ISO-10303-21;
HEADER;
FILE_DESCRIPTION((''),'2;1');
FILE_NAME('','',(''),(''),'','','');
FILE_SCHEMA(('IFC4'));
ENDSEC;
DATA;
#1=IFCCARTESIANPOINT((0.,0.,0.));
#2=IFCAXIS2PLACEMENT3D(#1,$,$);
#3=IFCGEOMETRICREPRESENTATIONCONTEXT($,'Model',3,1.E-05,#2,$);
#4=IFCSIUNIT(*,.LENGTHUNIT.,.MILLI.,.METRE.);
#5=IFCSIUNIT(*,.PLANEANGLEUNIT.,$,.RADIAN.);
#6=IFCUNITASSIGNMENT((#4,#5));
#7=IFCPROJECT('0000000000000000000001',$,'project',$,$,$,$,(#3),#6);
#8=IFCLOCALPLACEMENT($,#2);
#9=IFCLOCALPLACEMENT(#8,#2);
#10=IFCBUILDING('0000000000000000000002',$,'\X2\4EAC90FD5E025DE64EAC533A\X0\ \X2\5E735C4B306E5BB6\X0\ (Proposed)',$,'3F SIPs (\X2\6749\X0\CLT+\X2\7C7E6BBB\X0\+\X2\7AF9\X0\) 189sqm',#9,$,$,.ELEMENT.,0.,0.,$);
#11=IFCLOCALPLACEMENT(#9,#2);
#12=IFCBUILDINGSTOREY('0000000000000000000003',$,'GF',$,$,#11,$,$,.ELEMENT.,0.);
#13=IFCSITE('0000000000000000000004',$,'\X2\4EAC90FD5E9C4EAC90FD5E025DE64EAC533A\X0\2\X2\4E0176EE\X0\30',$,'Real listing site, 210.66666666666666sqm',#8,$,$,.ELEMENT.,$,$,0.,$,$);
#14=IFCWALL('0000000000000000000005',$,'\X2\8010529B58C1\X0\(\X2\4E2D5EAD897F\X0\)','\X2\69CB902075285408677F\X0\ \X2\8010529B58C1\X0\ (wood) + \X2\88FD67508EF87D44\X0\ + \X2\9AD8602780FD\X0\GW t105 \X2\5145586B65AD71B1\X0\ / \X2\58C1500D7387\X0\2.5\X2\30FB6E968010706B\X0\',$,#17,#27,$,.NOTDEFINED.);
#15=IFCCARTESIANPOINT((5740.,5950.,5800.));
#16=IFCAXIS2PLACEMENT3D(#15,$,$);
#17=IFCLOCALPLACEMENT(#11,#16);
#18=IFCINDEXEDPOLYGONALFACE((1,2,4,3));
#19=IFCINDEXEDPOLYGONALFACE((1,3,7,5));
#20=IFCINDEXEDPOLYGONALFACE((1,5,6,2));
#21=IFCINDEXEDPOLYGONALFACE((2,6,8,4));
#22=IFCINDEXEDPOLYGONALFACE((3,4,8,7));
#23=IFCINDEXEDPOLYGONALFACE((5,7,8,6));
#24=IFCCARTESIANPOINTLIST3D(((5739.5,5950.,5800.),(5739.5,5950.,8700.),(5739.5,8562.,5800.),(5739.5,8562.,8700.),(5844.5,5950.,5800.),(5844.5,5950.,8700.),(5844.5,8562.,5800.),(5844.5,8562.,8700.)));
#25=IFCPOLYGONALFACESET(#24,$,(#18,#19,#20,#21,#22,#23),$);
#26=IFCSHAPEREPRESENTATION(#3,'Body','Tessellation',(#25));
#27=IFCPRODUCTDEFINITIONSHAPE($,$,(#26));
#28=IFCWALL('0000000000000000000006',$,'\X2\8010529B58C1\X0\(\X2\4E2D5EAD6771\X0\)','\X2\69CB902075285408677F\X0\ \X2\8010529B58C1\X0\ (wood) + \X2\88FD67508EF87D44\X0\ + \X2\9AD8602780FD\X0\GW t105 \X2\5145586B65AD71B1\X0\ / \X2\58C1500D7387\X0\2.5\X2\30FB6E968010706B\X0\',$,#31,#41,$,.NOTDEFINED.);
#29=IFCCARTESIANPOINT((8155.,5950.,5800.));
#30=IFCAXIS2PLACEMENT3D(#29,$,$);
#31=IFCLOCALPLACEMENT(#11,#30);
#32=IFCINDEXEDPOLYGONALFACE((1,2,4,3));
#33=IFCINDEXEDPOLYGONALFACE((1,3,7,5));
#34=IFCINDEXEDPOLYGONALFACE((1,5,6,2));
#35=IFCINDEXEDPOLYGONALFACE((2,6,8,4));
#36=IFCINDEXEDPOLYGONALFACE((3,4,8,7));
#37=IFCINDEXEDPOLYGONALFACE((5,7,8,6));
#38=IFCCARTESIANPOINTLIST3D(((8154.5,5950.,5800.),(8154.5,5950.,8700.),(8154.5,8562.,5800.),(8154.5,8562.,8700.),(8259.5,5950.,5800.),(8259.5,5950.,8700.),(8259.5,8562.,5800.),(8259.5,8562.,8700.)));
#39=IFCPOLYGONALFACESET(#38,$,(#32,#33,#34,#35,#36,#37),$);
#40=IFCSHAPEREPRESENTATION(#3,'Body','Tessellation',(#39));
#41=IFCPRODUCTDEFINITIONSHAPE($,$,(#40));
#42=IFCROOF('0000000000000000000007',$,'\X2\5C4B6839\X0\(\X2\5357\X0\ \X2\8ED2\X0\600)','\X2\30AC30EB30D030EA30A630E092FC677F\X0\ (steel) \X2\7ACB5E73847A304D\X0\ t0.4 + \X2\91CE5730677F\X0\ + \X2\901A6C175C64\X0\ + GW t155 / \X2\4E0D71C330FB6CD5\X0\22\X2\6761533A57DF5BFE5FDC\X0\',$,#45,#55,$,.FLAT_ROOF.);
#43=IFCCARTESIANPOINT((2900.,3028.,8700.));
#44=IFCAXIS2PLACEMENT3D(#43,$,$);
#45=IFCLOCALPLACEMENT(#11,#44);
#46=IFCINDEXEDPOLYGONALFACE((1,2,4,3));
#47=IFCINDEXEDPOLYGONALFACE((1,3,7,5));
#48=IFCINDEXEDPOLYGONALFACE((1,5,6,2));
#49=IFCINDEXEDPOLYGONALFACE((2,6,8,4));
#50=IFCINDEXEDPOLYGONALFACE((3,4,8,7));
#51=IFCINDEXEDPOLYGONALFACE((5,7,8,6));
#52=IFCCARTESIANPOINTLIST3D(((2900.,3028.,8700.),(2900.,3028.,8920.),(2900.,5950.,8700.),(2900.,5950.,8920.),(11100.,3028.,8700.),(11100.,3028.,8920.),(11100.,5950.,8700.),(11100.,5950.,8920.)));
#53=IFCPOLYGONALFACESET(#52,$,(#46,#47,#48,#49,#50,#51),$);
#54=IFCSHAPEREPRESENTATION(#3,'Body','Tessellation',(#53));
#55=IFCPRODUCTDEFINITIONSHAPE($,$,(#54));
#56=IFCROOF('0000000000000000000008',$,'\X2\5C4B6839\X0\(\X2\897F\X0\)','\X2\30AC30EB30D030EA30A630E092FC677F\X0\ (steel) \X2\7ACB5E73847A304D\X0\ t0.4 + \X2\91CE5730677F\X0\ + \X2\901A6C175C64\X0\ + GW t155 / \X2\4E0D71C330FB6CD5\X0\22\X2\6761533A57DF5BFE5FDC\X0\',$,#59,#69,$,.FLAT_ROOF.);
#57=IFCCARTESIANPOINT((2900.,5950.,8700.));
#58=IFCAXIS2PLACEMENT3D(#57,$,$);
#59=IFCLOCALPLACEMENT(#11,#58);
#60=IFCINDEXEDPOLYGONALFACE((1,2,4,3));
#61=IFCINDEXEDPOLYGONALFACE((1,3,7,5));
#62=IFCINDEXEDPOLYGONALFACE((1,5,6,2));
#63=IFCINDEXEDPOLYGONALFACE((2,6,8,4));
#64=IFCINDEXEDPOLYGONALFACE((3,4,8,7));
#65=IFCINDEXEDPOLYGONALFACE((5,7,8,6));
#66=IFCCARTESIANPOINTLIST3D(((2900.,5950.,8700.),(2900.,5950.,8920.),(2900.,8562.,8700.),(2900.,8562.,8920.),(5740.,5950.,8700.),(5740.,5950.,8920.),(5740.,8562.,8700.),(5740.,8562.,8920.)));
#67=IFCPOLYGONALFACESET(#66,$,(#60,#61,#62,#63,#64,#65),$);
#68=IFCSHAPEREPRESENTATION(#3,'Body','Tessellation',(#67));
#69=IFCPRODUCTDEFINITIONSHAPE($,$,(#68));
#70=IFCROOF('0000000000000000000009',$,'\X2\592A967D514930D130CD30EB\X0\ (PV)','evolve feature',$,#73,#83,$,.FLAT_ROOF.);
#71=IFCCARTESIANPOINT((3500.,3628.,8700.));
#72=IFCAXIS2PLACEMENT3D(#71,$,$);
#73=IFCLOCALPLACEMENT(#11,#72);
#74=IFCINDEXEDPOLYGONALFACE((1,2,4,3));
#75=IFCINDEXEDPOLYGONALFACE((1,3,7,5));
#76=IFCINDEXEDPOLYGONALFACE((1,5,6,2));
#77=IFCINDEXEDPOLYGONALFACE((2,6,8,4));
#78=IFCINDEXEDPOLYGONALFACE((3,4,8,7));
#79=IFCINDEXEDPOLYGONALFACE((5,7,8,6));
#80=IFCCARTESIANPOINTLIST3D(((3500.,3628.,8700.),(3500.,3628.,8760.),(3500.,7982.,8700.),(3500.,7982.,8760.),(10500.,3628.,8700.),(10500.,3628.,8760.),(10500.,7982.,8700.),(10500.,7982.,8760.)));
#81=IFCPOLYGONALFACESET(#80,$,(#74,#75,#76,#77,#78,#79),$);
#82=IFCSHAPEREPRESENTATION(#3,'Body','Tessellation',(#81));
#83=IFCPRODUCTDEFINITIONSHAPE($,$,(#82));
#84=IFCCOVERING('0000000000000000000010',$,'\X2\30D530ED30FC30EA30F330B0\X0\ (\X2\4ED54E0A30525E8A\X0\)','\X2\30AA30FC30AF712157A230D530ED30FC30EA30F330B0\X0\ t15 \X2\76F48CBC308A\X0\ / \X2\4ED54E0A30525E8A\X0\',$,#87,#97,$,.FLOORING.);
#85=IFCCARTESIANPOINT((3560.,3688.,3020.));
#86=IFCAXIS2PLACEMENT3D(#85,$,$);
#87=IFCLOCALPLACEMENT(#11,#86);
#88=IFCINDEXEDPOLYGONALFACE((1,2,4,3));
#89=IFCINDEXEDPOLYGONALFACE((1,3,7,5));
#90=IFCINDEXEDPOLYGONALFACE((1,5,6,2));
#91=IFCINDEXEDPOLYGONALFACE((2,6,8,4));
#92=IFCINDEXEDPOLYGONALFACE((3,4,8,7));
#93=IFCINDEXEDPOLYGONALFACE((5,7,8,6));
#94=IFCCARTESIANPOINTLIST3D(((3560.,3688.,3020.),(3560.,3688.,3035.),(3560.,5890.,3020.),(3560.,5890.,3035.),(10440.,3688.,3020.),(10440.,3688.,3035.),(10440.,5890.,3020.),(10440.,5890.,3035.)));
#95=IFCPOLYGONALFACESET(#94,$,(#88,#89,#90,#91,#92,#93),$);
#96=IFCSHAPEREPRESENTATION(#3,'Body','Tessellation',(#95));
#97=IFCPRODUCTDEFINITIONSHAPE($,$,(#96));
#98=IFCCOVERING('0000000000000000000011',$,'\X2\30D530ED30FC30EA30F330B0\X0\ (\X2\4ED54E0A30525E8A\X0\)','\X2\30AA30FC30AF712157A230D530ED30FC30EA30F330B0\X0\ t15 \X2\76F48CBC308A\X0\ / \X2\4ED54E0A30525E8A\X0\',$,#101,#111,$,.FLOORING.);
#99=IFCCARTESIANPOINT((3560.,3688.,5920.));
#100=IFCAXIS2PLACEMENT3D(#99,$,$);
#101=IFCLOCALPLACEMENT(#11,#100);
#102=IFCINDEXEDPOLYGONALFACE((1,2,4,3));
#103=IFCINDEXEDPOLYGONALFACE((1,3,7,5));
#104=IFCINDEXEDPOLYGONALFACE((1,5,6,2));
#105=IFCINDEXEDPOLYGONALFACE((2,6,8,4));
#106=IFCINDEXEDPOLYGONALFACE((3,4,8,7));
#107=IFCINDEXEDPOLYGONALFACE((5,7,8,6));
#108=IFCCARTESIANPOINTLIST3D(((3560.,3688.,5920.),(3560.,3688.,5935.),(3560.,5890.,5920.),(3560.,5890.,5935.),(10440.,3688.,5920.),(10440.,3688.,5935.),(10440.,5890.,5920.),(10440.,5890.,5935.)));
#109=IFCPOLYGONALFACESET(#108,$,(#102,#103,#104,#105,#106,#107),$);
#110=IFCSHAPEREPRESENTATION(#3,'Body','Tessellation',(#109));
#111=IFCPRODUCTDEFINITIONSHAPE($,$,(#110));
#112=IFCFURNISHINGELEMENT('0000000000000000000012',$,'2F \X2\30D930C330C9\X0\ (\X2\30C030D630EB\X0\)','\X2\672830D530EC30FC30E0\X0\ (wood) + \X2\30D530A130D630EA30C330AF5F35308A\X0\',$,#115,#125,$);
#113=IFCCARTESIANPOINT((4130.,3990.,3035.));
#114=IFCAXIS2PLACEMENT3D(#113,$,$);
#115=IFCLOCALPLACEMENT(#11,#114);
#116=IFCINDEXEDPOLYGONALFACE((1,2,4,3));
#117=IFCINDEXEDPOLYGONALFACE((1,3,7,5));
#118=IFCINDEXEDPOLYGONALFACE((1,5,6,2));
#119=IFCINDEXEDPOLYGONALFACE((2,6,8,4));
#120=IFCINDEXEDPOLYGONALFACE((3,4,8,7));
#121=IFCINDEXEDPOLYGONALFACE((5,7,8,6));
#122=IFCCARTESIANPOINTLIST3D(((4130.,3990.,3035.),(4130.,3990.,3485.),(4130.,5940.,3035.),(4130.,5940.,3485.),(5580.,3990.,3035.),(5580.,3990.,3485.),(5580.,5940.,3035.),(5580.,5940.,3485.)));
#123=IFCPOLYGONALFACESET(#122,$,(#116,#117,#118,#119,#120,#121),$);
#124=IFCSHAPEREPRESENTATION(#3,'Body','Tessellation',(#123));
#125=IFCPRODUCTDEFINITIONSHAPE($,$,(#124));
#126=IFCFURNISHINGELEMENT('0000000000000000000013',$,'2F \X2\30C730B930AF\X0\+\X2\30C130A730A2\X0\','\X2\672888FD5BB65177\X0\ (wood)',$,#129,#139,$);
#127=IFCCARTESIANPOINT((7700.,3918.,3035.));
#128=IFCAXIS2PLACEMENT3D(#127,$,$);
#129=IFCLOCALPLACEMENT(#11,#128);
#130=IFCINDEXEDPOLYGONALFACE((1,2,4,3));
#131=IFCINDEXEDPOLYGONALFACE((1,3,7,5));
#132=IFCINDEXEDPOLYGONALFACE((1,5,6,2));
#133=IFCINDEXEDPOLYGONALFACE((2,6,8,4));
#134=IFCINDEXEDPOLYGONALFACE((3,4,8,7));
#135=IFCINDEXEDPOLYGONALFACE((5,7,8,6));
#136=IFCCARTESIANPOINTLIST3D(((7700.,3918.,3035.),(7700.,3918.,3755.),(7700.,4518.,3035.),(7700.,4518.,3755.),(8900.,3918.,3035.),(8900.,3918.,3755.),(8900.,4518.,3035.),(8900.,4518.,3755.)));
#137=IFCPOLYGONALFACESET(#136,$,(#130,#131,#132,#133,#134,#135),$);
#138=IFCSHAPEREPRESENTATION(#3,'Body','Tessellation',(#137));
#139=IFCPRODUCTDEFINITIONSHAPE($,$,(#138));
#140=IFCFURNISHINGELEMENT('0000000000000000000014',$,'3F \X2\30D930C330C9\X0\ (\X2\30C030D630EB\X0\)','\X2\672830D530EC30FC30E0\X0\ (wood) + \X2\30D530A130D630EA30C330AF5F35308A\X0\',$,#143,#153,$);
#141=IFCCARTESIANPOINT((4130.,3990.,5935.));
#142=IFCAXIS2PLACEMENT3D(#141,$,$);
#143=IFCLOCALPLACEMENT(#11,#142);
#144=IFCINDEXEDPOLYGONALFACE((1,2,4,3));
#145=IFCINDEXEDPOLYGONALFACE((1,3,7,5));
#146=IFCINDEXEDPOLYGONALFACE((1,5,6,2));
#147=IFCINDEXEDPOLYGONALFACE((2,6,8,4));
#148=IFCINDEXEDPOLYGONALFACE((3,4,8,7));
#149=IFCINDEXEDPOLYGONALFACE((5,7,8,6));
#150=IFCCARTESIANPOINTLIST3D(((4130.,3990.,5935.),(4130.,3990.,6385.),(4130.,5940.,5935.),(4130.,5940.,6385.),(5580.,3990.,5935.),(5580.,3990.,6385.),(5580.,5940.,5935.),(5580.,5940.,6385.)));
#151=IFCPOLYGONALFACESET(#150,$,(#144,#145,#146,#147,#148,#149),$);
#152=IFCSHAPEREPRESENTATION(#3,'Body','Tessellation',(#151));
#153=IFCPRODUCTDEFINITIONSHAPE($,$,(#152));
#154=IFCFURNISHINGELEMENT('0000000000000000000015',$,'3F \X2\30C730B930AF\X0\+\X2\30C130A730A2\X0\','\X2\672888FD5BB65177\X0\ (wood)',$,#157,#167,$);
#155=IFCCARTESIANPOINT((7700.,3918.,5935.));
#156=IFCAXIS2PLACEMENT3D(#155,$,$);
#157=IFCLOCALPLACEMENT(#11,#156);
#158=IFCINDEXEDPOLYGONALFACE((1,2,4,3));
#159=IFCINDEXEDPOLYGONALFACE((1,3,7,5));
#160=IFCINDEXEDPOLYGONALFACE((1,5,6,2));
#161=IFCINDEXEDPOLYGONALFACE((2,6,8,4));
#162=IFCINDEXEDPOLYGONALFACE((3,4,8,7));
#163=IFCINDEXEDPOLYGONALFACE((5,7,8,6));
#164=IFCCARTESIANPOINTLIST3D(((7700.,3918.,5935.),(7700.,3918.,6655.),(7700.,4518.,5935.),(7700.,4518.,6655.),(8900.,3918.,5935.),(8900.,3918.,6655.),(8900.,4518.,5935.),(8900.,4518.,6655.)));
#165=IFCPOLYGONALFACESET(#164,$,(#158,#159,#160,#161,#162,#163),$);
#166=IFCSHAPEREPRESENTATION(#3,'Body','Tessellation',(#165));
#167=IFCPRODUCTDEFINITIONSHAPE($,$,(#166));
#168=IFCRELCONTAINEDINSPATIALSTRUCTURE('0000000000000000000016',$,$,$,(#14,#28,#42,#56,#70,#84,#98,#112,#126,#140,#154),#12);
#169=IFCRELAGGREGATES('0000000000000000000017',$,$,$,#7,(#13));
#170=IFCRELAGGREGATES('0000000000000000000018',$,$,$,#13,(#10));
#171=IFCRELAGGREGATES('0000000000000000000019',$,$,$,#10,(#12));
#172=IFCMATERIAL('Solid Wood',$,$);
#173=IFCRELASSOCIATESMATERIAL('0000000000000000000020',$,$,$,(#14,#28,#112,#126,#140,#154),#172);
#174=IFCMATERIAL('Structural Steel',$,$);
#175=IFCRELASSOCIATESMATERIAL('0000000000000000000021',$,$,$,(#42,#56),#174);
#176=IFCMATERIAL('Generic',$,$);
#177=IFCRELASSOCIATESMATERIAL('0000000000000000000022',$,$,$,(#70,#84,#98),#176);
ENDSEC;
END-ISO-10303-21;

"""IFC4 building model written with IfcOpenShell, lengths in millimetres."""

from ifc_helpers import new_model, si_unit, frame, frame_2d, origin, place, context, project, spatial, rectangle, extrude, material, element, save


model = new_model("IFC4")

# Units and contexts
model_context = context("Model", 3, precision=1e-05, world=origin())
ifc_project = project(units=[si_unit("LENGTHUNIT", "METRE", prefix="MILLI"), si_unit("PLANEANGLEUNIT", "RADIAN")], contexts=[model_context])

# Site, building, storey
site_placement = place(None, origin())
site = spatial("IfcSite", under=ifc_project, at=site_placement, Name="京都府京都市左京区2丁目30", ObjectType="Real listing site, 210.66666666666666sqm", CompositionType="ELEMENT", RefElevation=0.0)
building_placement = place(site_placement, origin())
building = spatial("IfcBuilding", under=site, at=building_placement, Name="京都市左京区 平屋の家 (Proposed)", ObjectType="3F SIPs (杉CLT+籾殻+竹) 189sqm", CompositionType="ELEMENT", ElevationOfRefHeight=0.0, ElevationOfTerrain=0.0)
storey_placement = place(building_placement, origin())
storey = spatial("IfcBuildingStorey", under=building, at=storey_placement, Name="GF", CompositionType="ELEMENT", Elevation=0.0)

# Shared definitions
ifc_material_1 = material(Name="Solid Wood")

# Walls
wall_1_placement = place(storey_placement, frame((5740.0, 5950.0, 5800.0)))
element("IfcWall", 1, at=wall_1_placement, inside=storey, material=ifc_material_1, Name="耐力壁(中庭西)", Description="構造用合板 耐力壁 (wood) + 製材軸組 + 高性能GW t105 充填断熱 / 壁倍率2.5・準耐火", PredefinedType="NOTDEFINED", context=model_context, shape_type="SweptSolid", body=[
    extrude(rectangle(XDim=105.0, YDim=2612.0, at=frame_2d((52.0, 1306.0))), frame((5740.0, 5950.0, 5800.0)), (0.0, 0.0, 1.0), 2900.0),
])
wall_2_placement = place(storey_placement, frame((8155.0, 5950.0, 5800.0)))
element("IfcWall", 2, at=wall_2_placement, inside=storey, material=ifc_material_1, Name="耐力壁(中庭東)", Description="構造用合板 耐力壁 (wood) + 製材軸組 + 高性能GW t105 充填断熱 / 壁倍率2.5・準耐火", PredefinedType="NOTDEFINED", context=model_context, shape_type="SweptSolid", body=[
    extrude(rectangle(XDim=105.0, YDim=2612.0, at=frame_2d((52.0, 1306.0))), frame((8155.0, 5950.0, 5800.0)), (0.0, 0.0, 1.0), 2900.0),
])

# Roofs
ifc_material_2 = material(Name="Structural Steel")
roof_1_placement = place(storey_placement, frame((2900.0, 3028.0, 8700.0)))
element("IfcRoof", 3, at=roof_1_placement, inside=storey, material=ifc_material_2, Name="屋根(南 軒600)", Description="ガルバリウム鋼板 (steel) 立平葺き t0.4 + 野地板 + 通気層 + GW t155 / 不燃・法22条区域対応", PredefinedType="FLAT_ROOF", context=model_context, shape_type="SweptSolid", body=[
    extrude(rectangle(XDim=8200.0, YDim=2922.0, at=frame_2d((4100.0, 1461.0))), frame((2900.0, 3028.0, 8700.0)), (0.0, 0.0, 1.0), 220.0),
])
roof_2_placement = place(storey_placement, frame((2900.0, 5950.0, 8700.0)))
element("IfcRoof", 4, at=roof_2_placement, inside=storey, material=ifc_material_2, Name="屋根(西)", Description="ガルバリウム鋼板 (steel) 立平葺き t0.4 + 野地板 + 通気層 + GW t155 / 不燃・法22条区域対応", PredefinedType="FLAT_ROOF", context=model_context, shape_type="SweptSolid", body=[
    extrude(rectangle(XDim=2840.0, YDim=2612.0, at=frame_2d((1420.0, 1306.0))), frame((2900.0, 5950.0, 8700.0)), (0.0, 0.0, 1.0), 220.0),
])
ifc_material_3 = material(Name="Generic")
roof_3_placement = place(storey_placement, frame((3500.0, 3628.0, 8700.0)))
element("IfcRoof", 5, at=roof_3_placement, inside=storey, material=ifc_material_3, Name="太陽光パネル (PV)", Description="evolve feature", PredefinedType="FLAT_ROOF", context=model_context, shape_type="SweptSolid", body=[
    extrude(rectangle(XDim=7000.0, YDim=4354.0, at=frame_2d((3500.0, 2177.0))), frame((3500.0, 3628.0, 8700.0)), (0.0, 0.0, 1.0), 60.0),
])

# Coverings
covering_1_placement = place(storey_placement, frame((3560.0, 3688.0, 3020.0)))
element("IfcCovering", 6, at=covering_1_placement, inside=storey, material=ifc_material_3, Name="フローリング (仕上げ床)", Description="オーク無垢フローリング t15 直貼り / 仕上げ床", PredefinedType="FLOORING", context=model_context, shape_type="SweptSolid", body=[
    extrude(rectangle(XDim=6880.0, YDim=2202.0, at=frame_2d((3440.0, 1101.0))), frame((3560.0, 3688.0, 3020.0)), (0.0, 0.0, 1.0), 15.0),
])
covering_2_placement = place(storey_placement, frame((3560.0, 3688.0, 5920.0)))
element("IfcCovering", 7, at=covering_2_placement, inside=storey, material=ifc_material_3, Name="フローリング (仕上げ床)", Description="オーク無垢フローリング t15 直貼り / 仕上げ床", PredefinedType="FLOORING", context=model_context, shape_type="SweptSolid", body=[
    extrude(rectangle(XDim=6880.0, YDim=2202.0, at=frame_2d((3440.0, 1101.0))), frame((3560.0, 3688.0, 5920.0)), (0.0, 0.0, 1.0), 15.0),
])

# Furnishing elements
furnishing_1_placement = place(storey_placement, frame((4130.0, 3990.0, 3035.0)))
element("IfcFurnishingElement", 8, at=furnishing_1_placement, inside=storey, material=ifc_material_1, Name="2F ベッド (ダブル)", Description="木フレーム (wood) + ファブリック張り", context=model_context, shape_type="SweptSolid", body=[
    extrude(rectangle(XDim=1450.0, YDim=1950.0, at=frame_2d((725.0, 975.0))), frame((4130.0, 3990.0, 3035.0)), (0.0, 0.0, 1.0), 450.0),
])
furnishing_2_placement = place(storey_placement, frame((7700.0, 3918.0, 3035.0)))
element("IfcFurnishingElement", 9, at=furnishing_2_placement, inside=storey, material=ifc_material_1, Name="2F デスク+チェア", Description="木製家具 (wood)", context=model_context, shape_type="SweptSolid", body=[
    extrude(rectangle(XDim=1200.0, YDim=600.0, at=frame_2d((600.0, 300.0))), frame((7700.0, 3918.0, 3035.0)), (0.0, 0.0, 1.0), 720.0),
])
furnishing_3_placement = place(storey_placement, frame((4130.0, 3990.0, 5935.0)))
element("IfcFurnishingElement", 10, at=furnishing_3_placement, inside=storey, material=ifc_material_1, Name="3F ベッド (ダブル)", Description="木フレーム (wood) + ファブリック張り", context=model_context, shape_type="SweptSolid", body=[
    extrude(rectangle(XDim=1450.0, YDim=1950.0, at=frame_2d((725.0, 975.0))), frame((4130.0, 3990.0, 5935.0)), (0.0, 0.0, 1.0), 450.0),
])
furnishing_4_placement = place(storey_placement, frame((7700.0, 3918.0, 5935.0)))
element("IfcFurnishingElement", 11, at=furnishing_4_placement, inside=storey, material=ifc_material_1, Name="3F デスク+チェア", Description="木製家具 (wood)", context=model_context, shape_type="SweptSolid", body=[
    extrude(rectangle(XDim=1200.0, YDim=600.0, at=frame_2d((600.0, 300.0))), frame((7700.0, 3918.0, 5935.0)), (0.0, 0.0, 1.0), 720.0),
])

save(model, "model.ifc")
